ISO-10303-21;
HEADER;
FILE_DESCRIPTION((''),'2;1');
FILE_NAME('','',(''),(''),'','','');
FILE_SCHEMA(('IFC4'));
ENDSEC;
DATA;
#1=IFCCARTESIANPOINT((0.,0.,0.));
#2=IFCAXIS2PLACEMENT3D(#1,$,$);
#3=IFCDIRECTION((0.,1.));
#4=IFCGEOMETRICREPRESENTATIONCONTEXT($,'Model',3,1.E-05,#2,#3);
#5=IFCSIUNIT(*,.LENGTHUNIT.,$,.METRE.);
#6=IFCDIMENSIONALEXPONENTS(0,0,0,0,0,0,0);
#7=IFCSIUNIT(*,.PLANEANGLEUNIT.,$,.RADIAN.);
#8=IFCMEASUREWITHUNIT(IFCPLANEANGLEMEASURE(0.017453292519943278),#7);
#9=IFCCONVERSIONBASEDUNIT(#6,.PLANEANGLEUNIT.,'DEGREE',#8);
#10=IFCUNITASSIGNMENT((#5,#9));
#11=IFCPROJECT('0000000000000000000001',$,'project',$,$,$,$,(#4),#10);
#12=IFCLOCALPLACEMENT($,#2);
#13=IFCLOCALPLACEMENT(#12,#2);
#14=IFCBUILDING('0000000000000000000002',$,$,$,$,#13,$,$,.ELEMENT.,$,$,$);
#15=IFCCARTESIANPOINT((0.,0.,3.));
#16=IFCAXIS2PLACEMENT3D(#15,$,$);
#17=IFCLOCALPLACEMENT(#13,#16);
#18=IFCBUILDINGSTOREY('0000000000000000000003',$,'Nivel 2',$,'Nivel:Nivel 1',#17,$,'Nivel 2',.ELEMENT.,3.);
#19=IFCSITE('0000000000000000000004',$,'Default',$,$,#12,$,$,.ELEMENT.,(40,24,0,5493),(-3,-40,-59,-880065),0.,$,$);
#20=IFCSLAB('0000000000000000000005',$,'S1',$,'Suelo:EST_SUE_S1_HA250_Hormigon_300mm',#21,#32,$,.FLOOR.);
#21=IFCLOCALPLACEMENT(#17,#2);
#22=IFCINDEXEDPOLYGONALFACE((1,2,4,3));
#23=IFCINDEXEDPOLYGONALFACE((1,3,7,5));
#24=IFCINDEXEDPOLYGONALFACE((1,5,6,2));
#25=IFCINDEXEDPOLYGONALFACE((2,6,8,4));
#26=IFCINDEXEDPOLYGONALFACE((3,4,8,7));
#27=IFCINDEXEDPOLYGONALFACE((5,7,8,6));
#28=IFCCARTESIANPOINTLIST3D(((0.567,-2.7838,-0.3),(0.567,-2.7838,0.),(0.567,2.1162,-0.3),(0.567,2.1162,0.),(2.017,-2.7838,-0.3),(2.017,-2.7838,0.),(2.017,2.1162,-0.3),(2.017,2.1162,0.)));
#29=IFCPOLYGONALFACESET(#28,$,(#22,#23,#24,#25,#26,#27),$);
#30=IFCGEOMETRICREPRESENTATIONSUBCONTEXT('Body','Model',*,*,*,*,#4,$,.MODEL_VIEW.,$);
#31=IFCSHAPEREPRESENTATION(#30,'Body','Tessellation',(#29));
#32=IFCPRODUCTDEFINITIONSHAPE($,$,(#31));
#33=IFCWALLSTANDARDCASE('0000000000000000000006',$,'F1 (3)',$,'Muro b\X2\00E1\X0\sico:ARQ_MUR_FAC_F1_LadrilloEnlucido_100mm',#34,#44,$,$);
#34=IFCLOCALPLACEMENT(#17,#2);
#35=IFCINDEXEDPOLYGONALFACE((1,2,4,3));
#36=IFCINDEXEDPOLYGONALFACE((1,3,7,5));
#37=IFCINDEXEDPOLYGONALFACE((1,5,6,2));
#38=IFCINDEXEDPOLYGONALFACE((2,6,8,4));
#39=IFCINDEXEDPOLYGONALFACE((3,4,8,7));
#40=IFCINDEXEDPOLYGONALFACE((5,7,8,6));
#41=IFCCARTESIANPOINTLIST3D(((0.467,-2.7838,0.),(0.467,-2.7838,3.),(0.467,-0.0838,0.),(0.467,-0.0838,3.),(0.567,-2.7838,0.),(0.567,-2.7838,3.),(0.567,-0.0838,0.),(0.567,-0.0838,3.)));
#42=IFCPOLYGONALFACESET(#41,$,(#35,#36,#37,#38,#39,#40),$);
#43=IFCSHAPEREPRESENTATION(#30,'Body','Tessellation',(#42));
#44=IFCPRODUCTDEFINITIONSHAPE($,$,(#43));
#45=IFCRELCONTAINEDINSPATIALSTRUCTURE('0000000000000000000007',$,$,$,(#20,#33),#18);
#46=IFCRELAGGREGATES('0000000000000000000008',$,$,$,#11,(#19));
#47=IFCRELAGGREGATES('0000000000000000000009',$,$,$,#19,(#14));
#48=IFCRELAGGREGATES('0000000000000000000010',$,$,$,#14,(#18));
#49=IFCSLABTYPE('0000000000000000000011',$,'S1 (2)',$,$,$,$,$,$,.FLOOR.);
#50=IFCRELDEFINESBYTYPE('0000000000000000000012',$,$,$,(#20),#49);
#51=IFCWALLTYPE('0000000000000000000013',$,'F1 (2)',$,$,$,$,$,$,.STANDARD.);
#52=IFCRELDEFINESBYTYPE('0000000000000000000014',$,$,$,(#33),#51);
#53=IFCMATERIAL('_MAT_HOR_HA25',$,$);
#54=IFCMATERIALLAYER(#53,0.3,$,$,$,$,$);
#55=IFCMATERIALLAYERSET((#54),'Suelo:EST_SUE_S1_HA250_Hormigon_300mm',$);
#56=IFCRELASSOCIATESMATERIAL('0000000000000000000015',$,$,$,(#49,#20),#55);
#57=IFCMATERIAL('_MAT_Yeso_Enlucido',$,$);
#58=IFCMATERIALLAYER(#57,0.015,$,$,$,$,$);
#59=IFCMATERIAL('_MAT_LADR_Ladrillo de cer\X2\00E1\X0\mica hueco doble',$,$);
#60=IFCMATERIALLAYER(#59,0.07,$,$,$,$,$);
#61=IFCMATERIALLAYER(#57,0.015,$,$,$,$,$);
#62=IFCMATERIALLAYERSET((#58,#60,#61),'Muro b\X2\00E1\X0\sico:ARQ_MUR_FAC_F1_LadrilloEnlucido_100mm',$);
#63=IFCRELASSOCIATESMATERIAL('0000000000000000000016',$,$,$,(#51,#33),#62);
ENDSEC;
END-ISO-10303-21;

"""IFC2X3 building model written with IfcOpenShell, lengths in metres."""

from ifc_helpers import new_model, entity, si_unit, converted_unit, direction, frame, frame_2d, origin, place, context, subcontext, project, spatial, rectangle, extrude, material, layer, layer_set, layer_usage, type_object, element, save


model = new_model("IFC2X3")

# Units and contexts
model_context = context("Model", 3, precision=1e-05, world=origin(), true_north=direction((0.0, 1.0)))
body_context = subcontext(model_context, "Body", "Model", "MODEL_VIEW")
ifc_project = project(units=[si_unit("LENGTHUNIT", "METRE"), converted_unit("PLANEANGLEUNIT", "DEGREE", entity("IfcPlaneAngleMeasure", 0.017453292519943278), si_unit("PLANEANGLEUNIT", "RADIAN"), dimensions=[0, 0, 0, 0, 0, 0, 0])], contexts=[model_context])

# Site, building, storey
site_placement = place(None, origin())
site = spatial("IfcSite", under=ifc_project, at=site_placement, Name="Default", CompositionType="ELEMENT", RefLatitude=(40, 24, 0, 5493), RefLongitude=(-3, -40, -59, -880065), RefElevation=0.0)
building_placement = place(site_placement, origin())
building = spatial("IfcBuilding", under=site, at=building_placement, CompositionType="ELEMENT")
storey_placement = place(building_placement, frame((0.0, 0.0, 3.0)))
storey = spatial("IfcBuildingStorey", under=building, at=storey_placement, Name="Nivel 2", ObjectType="Nivel:Nivel 1", LongName="Nivel 2", CompositionType="ELEMENT", Elevation=3.0)

# Slab
ifc_material_1 = material(Name="_MAT_HOR_HA25")
ifc_layer_1 = layer(ifc_material_1, 0.3)
ifc_layer_set_1 = layer_set([ifc_layer_1], Name="Suelo:EST_SUE_S1_HA250_Hormigon_300mm")
ifc_layer_usage_1 = layer_usage(ifc_layer_set_1, "AXIS3", "POSITIVE", 0.0)
slab_type = type_object("IfcSlabType", Name="S1 (2)", PredefinedType="FLOOR", material=ifc_layer_set_1)
slab_placement = place(storey_placement, origin())
element("IfcSlab", 1, at=slab_placement, inside=storey, type_object=slab_type, material=ifc_layer_usage_1, Name="S1", ObjectType="Suelo:EST_SUE_S1_HA250_Hormigon_300mm", PredefinedType="FLOOR", context=body_context, shape_type="SweptSolid", body=[
    extrude(rectangle(XDim=4.9, YDim=1.45, at=frame_2d((0.0, 0.0), x_axis=(1.0, 0.0))), frame((1.292, -0.3338, 0.0), z_axis=(0.0, 0.0, -1.0), x_axis=(0.0, 1.0, 0.0)), (0.0, 0.0, 1.0), 0.3),
])

# Wall
ifc_material_2 = material(Name="_MAT_Yeso_Enlucido")
ifc_layer_2 = layer(ifc_material_2, 0.015)
ifc_material_3 = material(Name="_MAT_LADR_Ladrillo de cerámica hueco doble")
ifc_layer_3 = layer(ifc_material_3, 0.07)
ifc_layer_4 = layer(ifc_material_2, 0.015)
ifc_layer_set_2 = layer_set([ifc_layer_2, ifc_layer_3, ifc_layer_4], Name="Muro básico:ARQ_MUR_FAC_F1_LadrilloEnlucido_100mm")
ifc_layer_usage_2 = layer_usage(ifc_layer_set_2, "AXIS2", "NEGATIVE", 0.05)
wall_type = type_object("IfcWallType", Name="F1 (2)", PredefinedType="STANDARD", material=ifc_layer_set_2)
wall_placement = place(storey_placement, frame((0.517, -2.7838, 0.0), z_axis=(0.0, 0.0, 1.0), x_axis=(0.0, 1.0, 0.0)))
element("IfcWallStandardCase", 2, at=wall_placement, inside=storey, type_object=wall_type, material=ifc_layer_usage_2, Name="F1 (3)", ObjectType="Muro básico:ARQ_MUR_FAC_F1_LadrilloEnlucido_100mm", context=body_context, shape_type="SweptSolid", body=[
    extrude(rectangle(XDim=2.7, YDim=0.1, at=frame_2d((1.35, 0.0), x_axis=(-1.0, 0.0))), origin(), (0.0, 0.0, 1.0), 3.0),
])

save(model, "model.ifc")
